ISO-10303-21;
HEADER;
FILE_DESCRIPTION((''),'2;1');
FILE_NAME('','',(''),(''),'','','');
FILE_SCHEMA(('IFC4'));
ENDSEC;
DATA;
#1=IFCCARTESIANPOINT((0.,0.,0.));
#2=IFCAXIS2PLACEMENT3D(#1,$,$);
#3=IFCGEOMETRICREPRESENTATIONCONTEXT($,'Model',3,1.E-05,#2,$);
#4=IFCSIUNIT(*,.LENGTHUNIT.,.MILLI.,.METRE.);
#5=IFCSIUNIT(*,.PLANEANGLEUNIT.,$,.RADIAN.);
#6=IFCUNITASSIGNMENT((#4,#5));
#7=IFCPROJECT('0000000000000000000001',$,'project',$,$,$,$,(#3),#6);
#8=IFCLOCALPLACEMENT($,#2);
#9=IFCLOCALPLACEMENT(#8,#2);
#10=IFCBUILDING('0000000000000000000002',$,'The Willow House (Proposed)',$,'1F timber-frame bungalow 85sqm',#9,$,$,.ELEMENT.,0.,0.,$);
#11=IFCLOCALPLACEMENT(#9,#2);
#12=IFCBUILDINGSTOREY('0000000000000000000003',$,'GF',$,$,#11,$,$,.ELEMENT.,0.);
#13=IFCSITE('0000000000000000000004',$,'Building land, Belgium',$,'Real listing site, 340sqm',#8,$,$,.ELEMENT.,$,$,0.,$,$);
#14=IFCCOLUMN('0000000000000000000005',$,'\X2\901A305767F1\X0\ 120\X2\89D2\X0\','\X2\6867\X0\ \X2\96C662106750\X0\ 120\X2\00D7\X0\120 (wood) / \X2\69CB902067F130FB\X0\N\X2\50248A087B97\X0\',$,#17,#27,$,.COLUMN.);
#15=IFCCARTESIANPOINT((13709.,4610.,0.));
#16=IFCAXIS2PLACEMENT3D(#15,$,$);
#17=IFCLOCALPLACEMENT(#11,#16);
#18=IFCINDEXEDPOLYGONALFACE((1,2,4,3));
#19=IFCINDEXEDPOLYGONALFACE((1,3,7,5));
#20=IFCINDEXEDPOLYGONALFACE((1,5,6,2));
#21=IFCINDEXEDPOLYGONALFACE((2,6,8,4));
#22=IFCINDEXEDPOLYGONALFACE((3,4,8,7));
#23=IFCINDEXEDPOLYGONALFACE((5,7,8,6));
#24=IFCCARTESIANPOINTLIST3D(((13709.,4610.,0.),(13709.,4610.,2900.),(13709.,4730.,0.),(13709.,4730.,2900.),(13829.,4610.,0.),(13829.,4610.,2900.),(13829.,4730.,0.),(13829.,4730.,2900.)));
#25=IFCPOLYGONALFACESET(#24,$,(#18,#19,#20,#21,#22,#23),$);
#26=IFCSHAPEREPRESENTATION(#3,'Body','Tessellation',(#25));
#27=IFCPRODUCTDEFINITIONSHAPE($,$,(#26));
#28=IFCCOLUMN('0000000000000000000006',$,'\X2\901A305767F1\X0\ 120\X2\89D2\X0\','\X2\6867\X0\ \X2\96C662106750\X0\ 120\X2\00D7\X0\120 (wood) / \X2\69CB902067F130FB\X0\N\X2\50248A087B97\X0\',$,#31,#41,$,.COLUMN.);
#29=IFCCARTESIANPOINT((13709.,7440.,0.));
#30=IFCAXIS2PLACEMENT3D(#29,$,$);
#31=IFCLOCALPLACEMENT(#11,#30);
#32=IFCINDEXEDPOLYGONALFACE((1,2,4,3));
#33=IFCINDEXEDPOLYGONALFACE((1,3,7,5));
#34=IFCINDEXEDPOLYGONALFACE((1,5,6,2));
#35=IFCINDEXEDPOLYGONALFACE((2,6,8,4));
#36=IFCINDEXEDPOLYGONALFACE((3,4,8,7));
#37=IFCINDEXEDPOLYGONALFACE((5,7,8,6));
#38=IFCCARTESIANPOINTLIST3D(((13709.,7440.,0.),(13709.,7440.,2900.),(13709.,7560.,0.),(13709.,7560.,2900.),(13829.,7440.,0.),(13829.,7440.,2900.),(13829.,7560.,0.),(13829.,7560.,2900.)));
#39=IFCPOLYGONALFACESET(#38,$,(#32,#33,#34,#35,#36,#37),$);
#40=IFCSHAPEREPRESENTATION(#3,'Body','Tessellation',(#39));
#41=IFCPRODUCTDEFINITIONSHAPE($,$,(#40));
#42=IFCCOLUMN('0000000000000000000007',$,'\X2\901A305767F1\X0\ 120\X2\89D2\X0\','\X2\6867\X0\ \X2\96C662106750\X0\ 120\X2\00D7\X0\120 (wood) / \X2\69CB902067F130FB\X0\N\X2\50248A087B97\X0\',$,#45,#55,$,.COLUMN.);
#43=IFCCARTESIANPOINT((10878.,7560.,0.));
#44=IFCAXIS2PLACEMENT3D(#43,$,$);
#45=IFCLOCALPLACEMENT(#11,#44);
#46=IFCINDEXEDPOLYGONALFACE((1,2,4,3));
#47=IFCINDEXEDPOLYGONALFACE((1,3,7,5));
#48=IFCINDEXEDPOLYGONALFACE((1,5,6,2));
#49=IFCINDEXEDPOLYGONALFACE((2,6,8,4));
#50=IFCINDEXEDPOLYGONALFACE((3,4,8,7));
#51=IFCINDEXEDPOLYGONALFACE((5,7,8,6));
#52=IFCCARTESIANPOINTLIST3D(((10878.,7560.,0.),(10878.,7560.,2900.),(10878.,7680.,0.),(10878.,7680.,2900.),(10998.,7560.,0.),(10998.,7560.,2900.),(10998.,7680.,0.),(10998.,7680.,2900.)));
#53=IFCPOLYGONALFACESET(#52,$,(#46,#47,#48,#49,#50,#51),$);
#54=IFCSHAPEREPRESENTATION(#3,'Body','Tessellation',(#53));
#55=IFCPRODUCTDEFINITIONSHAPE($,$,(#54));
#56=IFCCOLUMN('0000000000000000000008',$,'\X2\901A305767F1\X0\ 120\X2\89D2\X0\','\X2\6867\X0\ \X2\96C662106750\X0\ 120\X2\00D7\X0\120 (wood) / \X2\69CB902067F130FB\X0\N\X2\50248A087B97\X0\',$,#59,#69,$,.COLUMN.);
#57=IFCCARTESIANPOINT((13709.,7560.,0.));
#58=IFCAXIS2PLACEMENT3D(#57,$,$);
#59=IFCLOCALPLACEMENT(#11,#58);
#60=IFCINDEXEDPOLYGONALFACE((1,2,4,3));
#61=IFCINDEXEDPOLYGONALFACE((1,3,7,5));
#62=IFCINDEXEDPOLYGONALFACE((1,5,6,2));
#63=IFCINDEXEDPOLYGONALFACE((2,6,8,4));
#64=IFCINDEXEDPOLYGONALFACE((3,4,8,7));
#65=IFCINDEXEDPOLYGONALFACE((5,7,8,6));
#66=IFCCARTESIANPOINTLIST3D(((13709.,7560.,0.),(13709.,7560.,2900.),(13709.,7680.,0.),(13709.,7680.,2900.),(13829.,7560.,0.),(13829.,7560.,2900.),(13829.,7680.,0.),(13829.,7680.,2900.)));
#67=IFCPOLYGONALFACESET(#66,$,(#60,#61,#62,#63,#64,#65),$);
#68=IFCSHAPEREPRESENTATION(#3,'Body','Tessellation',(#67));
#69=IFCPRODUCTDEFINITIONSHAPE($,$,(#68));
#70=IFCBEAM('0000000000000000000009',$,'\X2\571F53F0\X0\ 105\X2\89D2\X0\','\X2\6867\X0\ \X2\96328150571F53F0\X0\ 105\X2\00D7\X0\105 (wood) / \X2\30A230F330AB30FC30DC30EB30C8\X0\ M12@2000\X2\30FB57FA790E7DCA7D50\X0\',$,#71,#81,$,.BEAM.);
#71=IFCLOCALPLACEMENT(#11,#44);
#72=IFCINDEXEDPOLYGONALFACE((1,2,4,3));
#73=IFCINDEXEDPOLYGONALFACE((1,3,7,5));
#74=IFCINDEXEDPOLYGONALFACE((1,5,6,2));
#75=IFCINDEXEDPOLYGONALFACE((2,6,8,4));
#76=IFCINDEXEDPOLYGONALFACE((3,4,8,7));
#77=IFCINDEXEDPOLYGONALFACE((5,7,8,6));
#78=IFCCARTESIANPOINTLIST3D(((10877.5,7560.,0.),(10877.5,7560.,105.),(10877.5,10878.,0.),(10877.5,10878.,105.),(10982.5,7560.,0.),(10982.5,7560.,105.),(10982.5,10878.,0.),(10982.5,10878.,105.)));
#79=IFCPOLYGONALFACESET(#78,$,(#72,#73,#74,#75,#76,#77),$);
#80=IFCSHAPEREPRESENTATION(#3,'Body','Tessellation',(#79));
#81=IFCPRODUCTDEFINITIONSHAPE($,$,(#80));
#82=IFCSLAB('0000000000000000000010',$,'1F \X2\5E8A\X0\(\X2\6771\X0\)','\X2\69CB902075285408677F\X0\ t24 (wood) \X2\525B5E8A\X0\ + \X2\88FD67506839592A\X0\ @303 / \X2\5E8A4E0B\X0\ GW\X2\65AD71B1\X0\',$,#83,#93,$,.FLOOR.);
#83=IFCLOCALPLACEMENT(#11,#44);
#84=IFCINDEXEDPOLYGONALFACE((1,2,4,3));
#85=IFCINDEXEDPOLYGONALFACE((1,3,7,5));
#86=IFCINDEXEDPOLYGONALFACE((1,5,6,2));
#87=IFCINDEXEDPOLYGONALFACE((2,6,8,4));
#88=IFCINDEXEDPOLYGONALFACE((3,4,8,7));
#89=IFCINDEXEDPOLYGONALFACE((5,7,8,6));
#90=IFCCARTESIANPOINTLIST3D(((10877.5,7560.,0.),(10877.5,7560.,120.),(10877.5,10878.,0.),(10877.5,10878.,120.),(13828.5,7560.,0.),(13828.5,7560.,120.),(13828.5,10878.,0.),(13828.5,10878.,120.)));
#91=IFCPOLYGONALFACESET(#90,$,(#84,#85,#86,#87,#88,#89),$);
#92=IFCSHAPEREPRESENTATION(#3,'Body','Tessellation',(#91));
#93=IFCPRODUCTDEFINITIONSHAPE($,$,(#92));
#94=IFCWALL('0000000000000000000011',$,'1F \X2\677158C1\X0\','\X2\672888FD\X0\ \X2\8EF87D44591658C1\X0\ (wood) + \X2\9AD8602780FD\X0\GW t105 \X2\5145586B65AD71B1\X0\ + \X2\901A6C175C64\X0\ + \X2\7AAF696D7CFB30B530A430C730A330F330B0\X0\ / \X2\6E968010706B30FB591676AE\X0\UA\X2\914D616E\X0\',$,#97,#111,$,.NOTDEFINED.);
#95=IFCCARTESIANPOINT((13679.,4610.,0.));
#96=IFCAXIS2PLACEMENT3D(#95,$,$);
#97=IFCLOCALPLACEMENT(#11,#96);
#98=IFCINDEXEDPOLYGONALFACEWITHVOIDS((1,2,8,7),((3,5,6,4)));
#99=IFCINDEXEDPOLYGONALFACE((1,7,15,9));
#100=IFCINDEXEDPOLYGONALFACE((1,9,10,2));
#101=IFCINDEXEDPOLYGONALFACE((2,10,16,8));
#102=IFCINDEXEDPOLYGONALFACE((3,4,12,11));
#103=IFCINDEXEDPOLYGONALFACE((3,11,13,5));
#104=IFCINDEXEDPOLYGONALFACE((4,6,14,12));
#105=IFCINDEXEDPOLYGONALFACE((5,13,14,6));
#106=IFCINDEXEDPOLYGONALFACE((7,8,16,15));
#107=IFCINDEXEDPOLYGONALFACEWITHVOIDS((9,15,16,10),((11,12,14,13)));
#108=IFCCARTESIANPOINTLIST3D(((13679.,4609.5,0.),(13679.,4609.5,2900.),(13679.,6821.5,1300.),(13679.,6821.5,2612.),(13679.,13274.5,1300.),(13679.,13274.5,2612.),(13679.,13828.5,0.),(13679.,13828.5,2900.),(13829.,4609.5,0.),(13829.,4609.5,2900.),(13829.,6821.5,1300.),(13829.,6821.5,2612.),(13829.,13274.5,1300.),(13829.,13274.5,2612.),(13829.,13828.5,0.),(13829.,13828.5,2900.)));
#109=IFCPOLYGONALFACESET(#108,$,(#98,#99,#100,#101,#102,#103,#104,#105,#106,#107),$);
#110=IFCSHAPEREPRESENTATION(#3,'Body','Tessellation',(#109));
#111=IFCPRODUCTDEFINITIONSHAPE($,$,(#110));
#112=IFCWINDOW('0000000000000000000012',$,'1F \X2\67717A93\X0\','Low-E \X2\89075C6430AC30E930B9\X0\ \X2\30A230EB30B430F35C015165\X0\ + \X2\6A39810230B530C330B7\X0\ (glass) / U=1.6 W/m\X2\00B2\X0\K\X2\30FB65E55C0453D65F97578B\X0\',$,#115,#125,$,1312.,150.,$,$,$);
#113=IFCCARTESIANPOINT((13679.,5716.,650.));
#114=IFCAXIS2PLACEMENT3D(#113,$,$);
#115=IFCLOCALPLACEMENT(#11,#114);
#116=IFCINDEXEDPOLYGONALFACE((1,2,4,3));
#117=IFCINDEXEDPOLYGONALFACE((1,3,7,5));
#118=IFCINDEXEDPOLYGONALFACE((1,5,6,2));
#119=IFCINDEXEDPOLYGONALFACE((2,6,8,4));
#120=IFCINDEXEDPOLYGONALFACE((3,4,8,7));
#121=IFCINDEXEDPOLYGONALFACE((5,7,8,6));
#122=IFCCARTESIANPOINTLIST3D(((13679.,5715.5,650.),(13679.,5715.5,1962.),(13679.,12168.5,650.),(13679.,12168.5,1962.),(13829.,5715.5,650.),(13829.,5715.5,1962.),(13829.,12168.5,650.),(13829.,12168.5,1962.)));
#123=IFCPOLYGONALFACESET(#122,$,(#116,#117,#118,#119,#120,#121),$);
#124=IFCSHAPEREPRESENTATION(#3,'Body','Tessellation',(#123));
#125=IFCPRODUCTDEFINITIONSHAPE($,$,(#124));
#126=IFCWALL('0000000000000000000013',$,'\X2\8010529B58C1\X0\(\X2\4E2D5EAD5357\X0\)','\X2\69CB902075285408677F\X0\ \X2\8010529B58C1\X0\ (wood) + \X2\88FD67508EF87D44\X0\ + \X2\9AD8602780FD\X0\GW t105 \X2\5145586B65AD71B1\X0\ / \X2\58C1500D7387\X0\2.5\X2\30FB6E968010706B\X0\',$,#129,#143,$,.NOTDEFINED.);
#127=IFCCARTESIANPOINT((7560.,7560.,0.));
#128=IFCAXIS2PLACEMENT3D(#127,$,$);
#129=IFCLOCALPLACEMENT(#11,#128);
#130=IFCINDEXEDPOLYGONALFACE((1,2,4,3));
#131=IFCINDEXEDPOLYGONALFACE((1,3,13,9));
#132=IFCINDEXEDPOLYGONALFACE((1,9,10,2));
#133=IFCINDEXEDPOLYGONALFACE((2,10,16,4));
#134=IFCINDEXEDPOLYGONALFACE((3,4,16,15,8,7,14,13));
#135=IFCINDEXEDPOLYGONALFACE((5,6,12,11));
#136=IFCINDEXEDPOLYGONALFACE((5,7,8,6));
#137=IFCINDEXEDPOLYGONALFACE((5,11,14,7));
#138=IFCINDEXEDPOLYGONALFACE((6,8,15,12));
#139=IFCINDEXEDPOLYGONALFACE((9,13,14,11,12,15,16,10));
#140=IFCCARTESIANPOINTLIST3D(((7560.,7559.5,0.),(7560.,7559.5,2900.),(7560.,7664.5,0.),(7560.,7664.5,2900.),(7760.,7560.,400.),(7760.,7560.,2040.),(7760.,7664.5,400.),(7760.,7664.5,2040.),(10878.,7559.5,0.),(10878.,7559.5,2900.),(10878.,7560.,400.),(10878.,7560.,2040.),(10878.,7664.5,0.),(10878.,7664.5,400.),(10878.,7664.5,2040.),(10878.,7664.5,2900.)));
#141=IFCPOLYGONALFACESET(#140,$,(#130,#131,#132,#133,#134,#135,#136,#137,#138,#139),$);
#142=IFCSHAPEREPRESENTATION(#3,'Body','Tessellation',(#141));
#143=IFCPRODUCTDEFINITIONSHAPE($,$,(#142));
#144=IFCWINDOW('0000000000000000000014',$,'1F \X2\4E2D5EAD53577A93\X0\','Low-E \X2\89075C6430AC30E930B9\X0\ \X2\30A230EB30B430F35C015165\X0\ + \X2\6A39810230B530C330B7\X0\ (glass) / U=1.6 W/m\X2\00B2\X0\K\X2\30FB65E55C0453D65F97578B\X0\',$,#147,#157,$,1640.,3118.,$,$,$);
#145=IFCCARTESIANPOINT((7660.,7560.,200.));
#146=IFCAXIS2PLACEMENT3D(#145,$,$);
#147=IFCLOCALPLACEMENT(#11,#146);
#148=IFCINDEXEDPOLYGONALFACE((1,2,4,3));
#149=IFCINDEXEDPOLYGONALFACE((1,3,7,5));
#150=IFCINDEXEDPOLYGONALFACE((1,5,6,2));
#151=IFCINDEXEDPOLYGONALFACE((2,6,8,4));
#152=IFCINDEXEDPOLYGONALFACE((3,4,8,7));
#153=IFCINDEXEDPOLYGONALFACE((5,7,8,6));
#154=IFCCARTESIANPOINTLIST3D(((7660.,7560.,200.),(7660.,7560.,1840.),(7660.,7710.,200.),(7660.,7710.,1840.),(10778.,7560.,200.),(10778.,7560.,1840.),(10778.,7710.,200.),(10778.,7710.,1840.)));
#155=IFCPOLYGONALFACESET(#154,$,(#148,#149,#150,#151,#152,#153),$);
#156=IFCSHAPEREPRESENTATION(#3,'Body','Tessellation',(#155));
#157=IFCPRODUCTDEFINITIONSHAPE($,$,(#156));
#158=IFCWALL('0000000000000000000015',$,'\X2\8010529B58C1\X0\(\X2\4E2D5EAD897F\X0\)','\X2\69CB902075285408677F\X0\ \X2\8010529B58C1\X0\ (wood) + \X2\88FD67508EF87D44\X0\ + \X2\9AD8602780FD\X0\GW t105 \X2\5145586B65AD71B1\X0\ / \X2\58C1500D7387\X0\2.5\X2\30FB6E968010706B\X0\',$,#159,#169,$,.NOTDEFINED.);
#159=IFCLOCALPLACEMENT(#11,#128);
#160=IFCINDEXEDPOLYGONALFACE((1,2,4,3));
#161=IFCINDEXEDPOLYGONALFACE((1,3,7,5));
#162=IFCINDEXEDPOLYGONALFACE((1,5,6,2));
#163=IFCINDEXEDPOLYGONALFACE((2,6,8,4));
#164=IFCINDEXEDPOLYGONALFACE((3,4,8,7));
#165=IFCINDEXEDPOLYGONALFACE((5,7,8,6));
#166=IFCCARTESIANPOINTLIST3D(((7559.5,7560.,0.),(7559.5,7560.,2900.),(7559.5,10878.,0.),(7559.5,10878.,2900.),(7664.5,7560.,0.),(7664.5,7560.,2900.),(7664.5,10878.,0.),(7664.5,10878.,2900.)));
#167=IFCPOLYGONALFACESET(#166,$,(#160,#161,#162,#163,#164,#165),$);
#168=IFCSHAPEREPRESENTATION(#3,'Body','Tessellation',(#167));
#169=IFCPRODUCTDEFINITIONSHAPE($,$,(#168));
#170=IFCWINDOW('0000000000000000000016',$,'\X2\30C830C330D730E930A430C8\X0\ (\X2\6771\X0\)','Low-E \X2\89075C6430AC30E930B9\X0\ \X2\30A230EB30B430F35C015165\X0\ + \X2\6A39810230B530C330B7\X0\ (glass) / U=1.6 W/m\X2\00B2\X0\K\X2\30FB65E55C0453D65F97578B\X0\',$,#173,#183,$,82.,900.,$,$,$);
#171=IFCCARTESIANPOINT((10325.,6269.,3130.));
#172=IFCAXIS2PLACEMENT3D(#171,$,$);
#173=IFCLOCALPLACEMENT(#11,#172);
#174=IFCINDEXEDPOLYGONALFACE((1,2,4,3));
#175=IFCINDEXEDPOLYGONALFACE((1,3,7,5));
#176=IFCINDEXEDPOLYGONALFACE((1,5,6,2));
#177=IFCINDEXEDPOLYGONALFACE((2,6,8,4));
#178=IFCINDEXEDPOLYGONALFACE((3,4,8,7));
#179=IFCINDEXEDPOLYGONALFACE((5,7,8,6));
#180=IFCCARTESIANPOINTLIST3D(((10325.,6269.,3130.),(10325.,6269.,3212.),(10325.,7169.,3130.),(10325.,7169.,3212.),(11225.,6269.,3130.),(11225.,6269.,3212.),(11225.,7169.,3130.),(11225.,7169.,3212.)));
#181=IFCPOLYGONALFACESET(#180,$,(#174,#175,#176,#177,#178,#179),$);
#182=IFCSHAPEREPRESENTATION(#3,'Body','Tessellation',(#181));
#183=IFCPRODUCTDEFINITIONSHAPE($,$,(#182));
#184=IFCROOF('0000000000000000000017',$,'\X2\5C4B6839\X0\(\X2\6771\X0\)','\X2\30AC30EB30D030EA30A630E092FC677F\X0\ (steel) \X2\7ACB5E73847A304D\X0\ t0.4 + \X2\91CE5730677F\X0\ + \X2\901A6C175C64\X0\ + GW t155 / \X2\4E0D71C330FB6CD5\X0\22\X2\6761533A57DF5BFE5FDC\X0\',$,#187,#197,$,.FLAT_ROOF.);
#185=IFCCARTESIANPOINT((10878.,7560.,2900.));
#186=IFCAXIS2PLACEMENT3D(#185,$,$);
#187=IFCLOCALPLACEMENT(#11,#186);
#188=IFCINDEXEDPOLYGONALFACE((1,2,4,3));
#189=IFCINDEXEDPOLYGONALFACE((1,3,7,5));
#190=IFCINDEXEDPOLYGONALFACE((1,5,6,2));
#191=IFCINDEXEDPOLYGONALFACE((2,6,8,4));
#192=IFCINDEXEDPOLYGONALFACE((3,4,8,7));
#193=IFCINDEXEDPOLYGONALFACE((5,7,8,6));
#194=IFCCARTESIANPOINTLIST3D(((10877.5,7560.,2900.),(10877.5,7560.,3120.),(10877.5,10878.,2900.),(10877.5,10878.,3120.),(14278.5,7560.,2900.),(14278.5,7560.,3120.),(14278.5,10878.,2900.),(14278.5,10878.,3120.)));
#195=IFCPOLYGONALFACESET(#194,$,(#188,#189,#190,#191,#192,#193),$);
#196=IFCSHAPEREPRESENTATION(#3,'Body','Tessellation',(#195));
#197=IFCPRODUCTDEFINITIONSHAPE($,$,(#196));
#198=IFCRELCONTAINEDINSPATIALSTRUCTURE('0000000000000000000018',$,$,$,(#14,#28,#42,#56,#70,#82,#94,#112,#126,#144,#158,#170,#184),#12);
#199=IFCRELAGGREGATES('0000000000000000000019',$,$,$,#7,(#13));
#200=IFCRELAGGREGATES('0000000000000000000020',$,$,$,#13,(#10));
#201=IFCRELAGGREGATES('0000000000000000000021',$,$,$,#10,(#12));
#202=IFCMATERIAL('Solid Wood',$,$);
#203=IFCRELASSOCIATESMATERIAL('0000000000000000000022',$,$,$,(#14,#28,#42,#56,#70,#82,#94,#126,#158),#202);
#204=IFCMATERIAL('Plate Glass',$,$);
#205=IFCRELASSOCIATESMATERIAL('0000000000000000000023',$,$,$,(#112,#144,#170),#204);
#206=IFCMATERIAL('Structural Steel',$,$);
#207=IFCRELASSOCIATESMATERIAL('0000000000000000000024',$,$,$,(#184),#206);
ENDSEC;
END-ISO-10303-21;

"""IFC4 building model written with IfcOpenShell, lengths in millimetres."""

from ifc_helpers import new_model, si_unit, frame, frame_2d, origin, place, context, project, spatial, rectangle, extrude, material, element, fill, save


model = new_model("IFC4")

# Units and contexts
model_context = context("Model", 3, precision=1e-05, world=origin())
ifc_project = project(units=[si_unit("LENGTHUNIT", "METRE", prefix="MILLI"), si_unit("PLANEANGLEUNIT", "RADIAN")], contexts=[model_context])

# Site, building, storey
site_placement = place(None, origin())
site = spatial("IfcSite", under=ifc_project, at=site_placement, Name="Building land, Belgium", ObjectType="Real listing site, 340sqm", CompositionType="ELEMENT", RefElevation=0.0)
building_placement = place(site_placement, origin())
building = spatial("IfcBuilding", under=site, at=building_placement, Name="The Willow House (Proposed)", ObjectType="1F timber-frame bungalow 85sqm", CompositionType="ELEMENT", ElevationOfRefHeight=0.0, ElevationOfTerrain=0.0)
storey_placement = place(building_placement, origin())
storey = spatial("IfcBuildingStorey", under=building, at=storey_placement, Name="GF", CompositionType="ELEMENT", Elevation=0.0)

# Columns
ifc_material_1 = material(Name="Solid Wood")
column_1_placement = place(storey_placement, frame((13709.0, 4610.0, 0.0)))
element("IfcColumn", 1, at=column_1_placement, inside=storey, material=ifc_material_1, Name="通し柱 120角", Description="桧 集成材 120×120 (wood) / 構造柱・N値計算", PredefinedType="COLUMN", context=model_context, shape_type="SweptSolid", body=[
    extrude(rectangle(XDim=120.0, YDim=120.0, at=frame_2d((60.0, 60.0))), frame((13709.0, 4610.0, 0.0)), (0.0, 0.0, 1.0), 2900.0),
])
column_2_placement = place(storey_placement, frame((13709.0, 7440.0, 0.0)))
element("IfcColumn", 2, at=column_2_placement, inside=storey, material=ifc_material_1, Name="通し柱 120角", Description="桧 集成材 120×120 (wood) / 構造柱・N値計算", PredefinedType="COLUMN", context=model_context, shape_type="SweptSolid", body=[
    extrude(rectangle(XDim=120.0, YDim=120.0, at=frame_2d((60.0, 60.0))), frame((13709.0, 7440.0, 0.0)), (0.0, 0.0, 1.0), 2900.0),
])
column_3_placement = place(storey_placement, frame((10878.0, 7560.0, 0.0)))
element("IfcColumn", 3, at=column_3_placement, inside=storey, material=ifc_material_1, Name="通し柱 120角", Description="桧 集成材 120×120 (wood) / 構造柱・N値計算", PredefinedType="COLUMN", context=model_context, shape_type="SweptSolid", body=[
    extrude(rectangle(XDim=120.0, YDim=120.0, at=frame_2d((60.0, 60.0))), frame((10878.0, 7560.0, 0.0)), (0.0, 0.0, 1.0), 2900.0),
])
column_4_placement = place(storey_placement, frame((13709.0, 7560.0, 0.0)))
element("IfcColumn", 4, at=column_4_placement, inside=storey, material=ifc_material_1, Name="通し柱 120角", Description="桧 集成材 120×120 (wood) / 構造柱・N値計算", PredefinedType="COLUMN", context=model_context, shape_type="SweptSolid", body=[
    extrude(rectangle(XDim=120.0, YDim=120.0, at=frame_2d((60.0, 60.0))), frame((13709.0, 7560.0, 0.0)), (0.0, 0.0, 1.0), 2900.0),
])

# Beam
beam_1_placement = place(storey_placement, frame((10878.0, 7560.0, 0.0)))
element("IfcBeam", 5, at=beam_1_placement, inside=storey, material=ifc_material_1, Name="土台 105角", Description="桧 防腐土台 105×105 (wood) / アンカーボルト M12@2000・基礎緊結", PredefinedType="BEAM", context=model_context, shape_type="SweptSolid", body=[
    extrude(rectangle(XDim=105.0, YDim=3318.0, at=frame_2d((52.0, 1659.0))), frame((10878.0, 7560.0, 0.0)), (0.0, 0.0, 1.0), 105.0),
])

# Slab
slab_placement = place(storey_placement, frame((10878.0, 7560.0, 0.0)))
element("IfcSlab", 6, at=slab_placement, inside=storey, material=ifc_material_1, Name="1F 床(東)", Description="構造用合板 t24 (wood) 剛床 + 製材根太 @303 / 床下 GW断熱", PredefinedType="FLOOR", context=model_context, shape_type="SweptSolid", body=[
    extrude(rectangle(XDim=2951.0, YDim=3318.0, at=frame_2d((1475.0, 1659.0))), frame((10878.0, 7560.0, 0.0)), (0.0, 0.0, 1.0), 120.0),
])

# Walls, openings, windows
wall_1_placement = place(storey_placement, frame((13679.0, 4610.0, 0.0)))
wall_1 = element("IfcWall", 7, at=wall_1_placement, inside=storey, material=ifc_material_1, Name="1F 東壁", Description="木製 軸組外壁 (wood) + 高性能GW t105 充填断熱 + 通気層 + 窯業系サイディング / 準耐火・外皮UA配慮", PredefinedType="NOTDEFINED", context=model_context, shape_type="SweptSolid", body=[
    extrude(rectangle(XDim=150.0, YDim=9219.0, at=frame_2d((75.0, 4609.0))), frame((13679.0, 4610.0, 0.0)), (0.0, 0.0, 1.0), 2900.0),
])
opening_1_placement = place(storey_placement, frame((13679.0, 5716.0, 650.0)))
opening_1 = element("IfcOpeningElement", 8, at=opening_1_placement, cuts=wall_1, PredefinedType="NOTDEFINED", context=model_context, shape_type="SweptSolid", body=[
    extrude(rectangle(XDim=150.0, YDim=6453.0, at=frame_2d((75.0, 3226.0))), frame((13679.0, 5716.0, 650.0)), (0.0, 0.0, 1.0), 1312.0),
])
ifc_material_2 = material(Name="Plate Glass")
window_1_placement = place(storey_placement, frame((13679.0, 5716.0, 650.0)))
window_1 = element("IfcWindow", 9, at=window_1_placement, inside=storey, material=ifc_material_2, Name="1F 東窓", Description="Low-E 複層ガラス アルゴン封入 + 樹脂サッシ (glass) / U=1.6 W/m²K・日射取得型", OverallHeight=1312.0, OverallWidth=150.0, context=model_context, shape_type="SweptSolid", body=[
    extrude(rectangle(XDim=150.0, YDim=6453.0, at=frame_2d((75.0, 3226.0))), frame((13679.0, 5716.0, 650.0)), (0.0, 0.0, 1.0), 1312.0),
])
fill(opening_1, window_1)
wall_2_placement = place(storey_placement, frame((7560.0, 7560.0, 0.0)))
wall_2 = element("IfcWall", 10, at=wall_2_placement, inside=storey, material=ifc_material_1, Name="耐力壁(中庭南)", Description="構造用合板 耐力壁 (wood) + 製材軸組 + 高性能GW t105 充填断熱 / 壁倍率2.5・準耐火", PredefinedType="NOTDEFINED", context=model_context, shape_type="SweptSolid", body=[
    extrude(rectangle(XDim=3318.0, YDim=105.0, at=frame_2d((1659.0, 52.0))), frame((7560.0, 7560.0, 0.0)), (0.0, 0.0, 1.0), 2900.0),
])
opening_2_placement = place(storey_placement, frame((7660.0, 7560.0, 200.0)))
opening_2 = element("IfcOpeningElement", 11, at=opening_2_placement, cuts=wall_2, PredefinedType="NOTDEFINED", context=model_context, shape_type="SweptSolid", body=[
    extrude(rectangle(XDim=3118.0, YDim=150.0, at=frame_2d((1559.0, 75.0))), frame((7660.0, 7560.0, 200.0)), (0.0, 0.0, 1.0), 1640.0),
])
window_2_placement = place(storey_placement, frame((7660.0, 7560.0, 200.0)))
window_2 = element("IfcWindow", 12, at=window_2_placement, inside=storey, material=ifc_material_2, Name="1F 中庭南窓", Description="Low-E 複層ガラス アルゴン封入 + 樹脂サッシ (glass) / U=1.6 W/m²K・日射取得型", OverallHeight=1640.0, OverallWidth=3118.0, context=model_context, shape_type="SweptSolid", body=[
    extrude(rectangle(XDim=3118.0, YDim=150.0, at=frame_2d((1559.0, 75.0))), frame((7660.0, 7560.0, 200.0)), (0.0, 0.0, 1.0), 1640.0),
])
fill(opening_2, window_2)

# Wall
wall_3_placement = place(storey_placement, frame((7560.0, 7560.0, 0.0)))
element("IfcWall", 13, at=wall_3_placement, inside=storey, material=ifc_material_1, Name="耐力壁(中庭西)", Description="構造用合板 耐力壁 (wood) + 製材軸組 + 高性能GW t105 充填断熱 / 壁倍率2.5・準耐火", PredefinedType="NOTDEFINED", context=model_context, shape_type="SweptSolid", body=[
    extrude(rectangle(XDim=105.0, YDim=3318.0, at=frame_2d((52.0, 1659.0))), frame((7560.0, 7560.0, 0.0)), (0.0, 0.0, 1.0), 2900.0),
])

# Window
window_3_placement = place(storey_placement, frame((10325.0, 6269.0, 3130.0)))
element("IfcWindow", 14, at=window_3_placement, inside=storey, material=ifc_material_2, Name="トップライト (東)", Description="Low-E 複層ガラス アルゴン封入 + 樹脂サッシ (glass) / U=1.6 W/m²K・日射取得型", OverallHeight=82.0, OverallWidth=900.0, context=model_context, shape_type="SweptSolid", body=[
    extrude(rectangle(XDim=900.0, YDim=900.0, at=frame_2d((450.0, 450.0))), frame((10325.0, 6269.0, 3130.0)), (0.0, 0.0, 1.0), 82.0),
])

# Roof
ifc_material_3 = material(Name="Structural Steel")
roof_placement = place(storey_placement, frame((10878.0, 7560.0, 2900.0)))
element("IfcRoof", 15, at=roof_placement, inside=storey, material=ifc_material_3, Name="屋根(東)", Description="ガルバリウム鋼板 (steel) 立平葺き t0.4 + 野地板 + 通気層 + GW t155 / 不燃・法22条区域対応", PredefinedType="FLAT_ROOF", context=model_context, shape_type="SweptSolid", body=[
    extrude(rectangle(XDim=3401.0, YDim=3318.0, at=frame_2d((1700.0, 1659.0))), frame((10878.0, 7560.0, 2900.0)), (0.0, 0.0, 1.0), 220.0),
])

save(model, "model.ifc")
